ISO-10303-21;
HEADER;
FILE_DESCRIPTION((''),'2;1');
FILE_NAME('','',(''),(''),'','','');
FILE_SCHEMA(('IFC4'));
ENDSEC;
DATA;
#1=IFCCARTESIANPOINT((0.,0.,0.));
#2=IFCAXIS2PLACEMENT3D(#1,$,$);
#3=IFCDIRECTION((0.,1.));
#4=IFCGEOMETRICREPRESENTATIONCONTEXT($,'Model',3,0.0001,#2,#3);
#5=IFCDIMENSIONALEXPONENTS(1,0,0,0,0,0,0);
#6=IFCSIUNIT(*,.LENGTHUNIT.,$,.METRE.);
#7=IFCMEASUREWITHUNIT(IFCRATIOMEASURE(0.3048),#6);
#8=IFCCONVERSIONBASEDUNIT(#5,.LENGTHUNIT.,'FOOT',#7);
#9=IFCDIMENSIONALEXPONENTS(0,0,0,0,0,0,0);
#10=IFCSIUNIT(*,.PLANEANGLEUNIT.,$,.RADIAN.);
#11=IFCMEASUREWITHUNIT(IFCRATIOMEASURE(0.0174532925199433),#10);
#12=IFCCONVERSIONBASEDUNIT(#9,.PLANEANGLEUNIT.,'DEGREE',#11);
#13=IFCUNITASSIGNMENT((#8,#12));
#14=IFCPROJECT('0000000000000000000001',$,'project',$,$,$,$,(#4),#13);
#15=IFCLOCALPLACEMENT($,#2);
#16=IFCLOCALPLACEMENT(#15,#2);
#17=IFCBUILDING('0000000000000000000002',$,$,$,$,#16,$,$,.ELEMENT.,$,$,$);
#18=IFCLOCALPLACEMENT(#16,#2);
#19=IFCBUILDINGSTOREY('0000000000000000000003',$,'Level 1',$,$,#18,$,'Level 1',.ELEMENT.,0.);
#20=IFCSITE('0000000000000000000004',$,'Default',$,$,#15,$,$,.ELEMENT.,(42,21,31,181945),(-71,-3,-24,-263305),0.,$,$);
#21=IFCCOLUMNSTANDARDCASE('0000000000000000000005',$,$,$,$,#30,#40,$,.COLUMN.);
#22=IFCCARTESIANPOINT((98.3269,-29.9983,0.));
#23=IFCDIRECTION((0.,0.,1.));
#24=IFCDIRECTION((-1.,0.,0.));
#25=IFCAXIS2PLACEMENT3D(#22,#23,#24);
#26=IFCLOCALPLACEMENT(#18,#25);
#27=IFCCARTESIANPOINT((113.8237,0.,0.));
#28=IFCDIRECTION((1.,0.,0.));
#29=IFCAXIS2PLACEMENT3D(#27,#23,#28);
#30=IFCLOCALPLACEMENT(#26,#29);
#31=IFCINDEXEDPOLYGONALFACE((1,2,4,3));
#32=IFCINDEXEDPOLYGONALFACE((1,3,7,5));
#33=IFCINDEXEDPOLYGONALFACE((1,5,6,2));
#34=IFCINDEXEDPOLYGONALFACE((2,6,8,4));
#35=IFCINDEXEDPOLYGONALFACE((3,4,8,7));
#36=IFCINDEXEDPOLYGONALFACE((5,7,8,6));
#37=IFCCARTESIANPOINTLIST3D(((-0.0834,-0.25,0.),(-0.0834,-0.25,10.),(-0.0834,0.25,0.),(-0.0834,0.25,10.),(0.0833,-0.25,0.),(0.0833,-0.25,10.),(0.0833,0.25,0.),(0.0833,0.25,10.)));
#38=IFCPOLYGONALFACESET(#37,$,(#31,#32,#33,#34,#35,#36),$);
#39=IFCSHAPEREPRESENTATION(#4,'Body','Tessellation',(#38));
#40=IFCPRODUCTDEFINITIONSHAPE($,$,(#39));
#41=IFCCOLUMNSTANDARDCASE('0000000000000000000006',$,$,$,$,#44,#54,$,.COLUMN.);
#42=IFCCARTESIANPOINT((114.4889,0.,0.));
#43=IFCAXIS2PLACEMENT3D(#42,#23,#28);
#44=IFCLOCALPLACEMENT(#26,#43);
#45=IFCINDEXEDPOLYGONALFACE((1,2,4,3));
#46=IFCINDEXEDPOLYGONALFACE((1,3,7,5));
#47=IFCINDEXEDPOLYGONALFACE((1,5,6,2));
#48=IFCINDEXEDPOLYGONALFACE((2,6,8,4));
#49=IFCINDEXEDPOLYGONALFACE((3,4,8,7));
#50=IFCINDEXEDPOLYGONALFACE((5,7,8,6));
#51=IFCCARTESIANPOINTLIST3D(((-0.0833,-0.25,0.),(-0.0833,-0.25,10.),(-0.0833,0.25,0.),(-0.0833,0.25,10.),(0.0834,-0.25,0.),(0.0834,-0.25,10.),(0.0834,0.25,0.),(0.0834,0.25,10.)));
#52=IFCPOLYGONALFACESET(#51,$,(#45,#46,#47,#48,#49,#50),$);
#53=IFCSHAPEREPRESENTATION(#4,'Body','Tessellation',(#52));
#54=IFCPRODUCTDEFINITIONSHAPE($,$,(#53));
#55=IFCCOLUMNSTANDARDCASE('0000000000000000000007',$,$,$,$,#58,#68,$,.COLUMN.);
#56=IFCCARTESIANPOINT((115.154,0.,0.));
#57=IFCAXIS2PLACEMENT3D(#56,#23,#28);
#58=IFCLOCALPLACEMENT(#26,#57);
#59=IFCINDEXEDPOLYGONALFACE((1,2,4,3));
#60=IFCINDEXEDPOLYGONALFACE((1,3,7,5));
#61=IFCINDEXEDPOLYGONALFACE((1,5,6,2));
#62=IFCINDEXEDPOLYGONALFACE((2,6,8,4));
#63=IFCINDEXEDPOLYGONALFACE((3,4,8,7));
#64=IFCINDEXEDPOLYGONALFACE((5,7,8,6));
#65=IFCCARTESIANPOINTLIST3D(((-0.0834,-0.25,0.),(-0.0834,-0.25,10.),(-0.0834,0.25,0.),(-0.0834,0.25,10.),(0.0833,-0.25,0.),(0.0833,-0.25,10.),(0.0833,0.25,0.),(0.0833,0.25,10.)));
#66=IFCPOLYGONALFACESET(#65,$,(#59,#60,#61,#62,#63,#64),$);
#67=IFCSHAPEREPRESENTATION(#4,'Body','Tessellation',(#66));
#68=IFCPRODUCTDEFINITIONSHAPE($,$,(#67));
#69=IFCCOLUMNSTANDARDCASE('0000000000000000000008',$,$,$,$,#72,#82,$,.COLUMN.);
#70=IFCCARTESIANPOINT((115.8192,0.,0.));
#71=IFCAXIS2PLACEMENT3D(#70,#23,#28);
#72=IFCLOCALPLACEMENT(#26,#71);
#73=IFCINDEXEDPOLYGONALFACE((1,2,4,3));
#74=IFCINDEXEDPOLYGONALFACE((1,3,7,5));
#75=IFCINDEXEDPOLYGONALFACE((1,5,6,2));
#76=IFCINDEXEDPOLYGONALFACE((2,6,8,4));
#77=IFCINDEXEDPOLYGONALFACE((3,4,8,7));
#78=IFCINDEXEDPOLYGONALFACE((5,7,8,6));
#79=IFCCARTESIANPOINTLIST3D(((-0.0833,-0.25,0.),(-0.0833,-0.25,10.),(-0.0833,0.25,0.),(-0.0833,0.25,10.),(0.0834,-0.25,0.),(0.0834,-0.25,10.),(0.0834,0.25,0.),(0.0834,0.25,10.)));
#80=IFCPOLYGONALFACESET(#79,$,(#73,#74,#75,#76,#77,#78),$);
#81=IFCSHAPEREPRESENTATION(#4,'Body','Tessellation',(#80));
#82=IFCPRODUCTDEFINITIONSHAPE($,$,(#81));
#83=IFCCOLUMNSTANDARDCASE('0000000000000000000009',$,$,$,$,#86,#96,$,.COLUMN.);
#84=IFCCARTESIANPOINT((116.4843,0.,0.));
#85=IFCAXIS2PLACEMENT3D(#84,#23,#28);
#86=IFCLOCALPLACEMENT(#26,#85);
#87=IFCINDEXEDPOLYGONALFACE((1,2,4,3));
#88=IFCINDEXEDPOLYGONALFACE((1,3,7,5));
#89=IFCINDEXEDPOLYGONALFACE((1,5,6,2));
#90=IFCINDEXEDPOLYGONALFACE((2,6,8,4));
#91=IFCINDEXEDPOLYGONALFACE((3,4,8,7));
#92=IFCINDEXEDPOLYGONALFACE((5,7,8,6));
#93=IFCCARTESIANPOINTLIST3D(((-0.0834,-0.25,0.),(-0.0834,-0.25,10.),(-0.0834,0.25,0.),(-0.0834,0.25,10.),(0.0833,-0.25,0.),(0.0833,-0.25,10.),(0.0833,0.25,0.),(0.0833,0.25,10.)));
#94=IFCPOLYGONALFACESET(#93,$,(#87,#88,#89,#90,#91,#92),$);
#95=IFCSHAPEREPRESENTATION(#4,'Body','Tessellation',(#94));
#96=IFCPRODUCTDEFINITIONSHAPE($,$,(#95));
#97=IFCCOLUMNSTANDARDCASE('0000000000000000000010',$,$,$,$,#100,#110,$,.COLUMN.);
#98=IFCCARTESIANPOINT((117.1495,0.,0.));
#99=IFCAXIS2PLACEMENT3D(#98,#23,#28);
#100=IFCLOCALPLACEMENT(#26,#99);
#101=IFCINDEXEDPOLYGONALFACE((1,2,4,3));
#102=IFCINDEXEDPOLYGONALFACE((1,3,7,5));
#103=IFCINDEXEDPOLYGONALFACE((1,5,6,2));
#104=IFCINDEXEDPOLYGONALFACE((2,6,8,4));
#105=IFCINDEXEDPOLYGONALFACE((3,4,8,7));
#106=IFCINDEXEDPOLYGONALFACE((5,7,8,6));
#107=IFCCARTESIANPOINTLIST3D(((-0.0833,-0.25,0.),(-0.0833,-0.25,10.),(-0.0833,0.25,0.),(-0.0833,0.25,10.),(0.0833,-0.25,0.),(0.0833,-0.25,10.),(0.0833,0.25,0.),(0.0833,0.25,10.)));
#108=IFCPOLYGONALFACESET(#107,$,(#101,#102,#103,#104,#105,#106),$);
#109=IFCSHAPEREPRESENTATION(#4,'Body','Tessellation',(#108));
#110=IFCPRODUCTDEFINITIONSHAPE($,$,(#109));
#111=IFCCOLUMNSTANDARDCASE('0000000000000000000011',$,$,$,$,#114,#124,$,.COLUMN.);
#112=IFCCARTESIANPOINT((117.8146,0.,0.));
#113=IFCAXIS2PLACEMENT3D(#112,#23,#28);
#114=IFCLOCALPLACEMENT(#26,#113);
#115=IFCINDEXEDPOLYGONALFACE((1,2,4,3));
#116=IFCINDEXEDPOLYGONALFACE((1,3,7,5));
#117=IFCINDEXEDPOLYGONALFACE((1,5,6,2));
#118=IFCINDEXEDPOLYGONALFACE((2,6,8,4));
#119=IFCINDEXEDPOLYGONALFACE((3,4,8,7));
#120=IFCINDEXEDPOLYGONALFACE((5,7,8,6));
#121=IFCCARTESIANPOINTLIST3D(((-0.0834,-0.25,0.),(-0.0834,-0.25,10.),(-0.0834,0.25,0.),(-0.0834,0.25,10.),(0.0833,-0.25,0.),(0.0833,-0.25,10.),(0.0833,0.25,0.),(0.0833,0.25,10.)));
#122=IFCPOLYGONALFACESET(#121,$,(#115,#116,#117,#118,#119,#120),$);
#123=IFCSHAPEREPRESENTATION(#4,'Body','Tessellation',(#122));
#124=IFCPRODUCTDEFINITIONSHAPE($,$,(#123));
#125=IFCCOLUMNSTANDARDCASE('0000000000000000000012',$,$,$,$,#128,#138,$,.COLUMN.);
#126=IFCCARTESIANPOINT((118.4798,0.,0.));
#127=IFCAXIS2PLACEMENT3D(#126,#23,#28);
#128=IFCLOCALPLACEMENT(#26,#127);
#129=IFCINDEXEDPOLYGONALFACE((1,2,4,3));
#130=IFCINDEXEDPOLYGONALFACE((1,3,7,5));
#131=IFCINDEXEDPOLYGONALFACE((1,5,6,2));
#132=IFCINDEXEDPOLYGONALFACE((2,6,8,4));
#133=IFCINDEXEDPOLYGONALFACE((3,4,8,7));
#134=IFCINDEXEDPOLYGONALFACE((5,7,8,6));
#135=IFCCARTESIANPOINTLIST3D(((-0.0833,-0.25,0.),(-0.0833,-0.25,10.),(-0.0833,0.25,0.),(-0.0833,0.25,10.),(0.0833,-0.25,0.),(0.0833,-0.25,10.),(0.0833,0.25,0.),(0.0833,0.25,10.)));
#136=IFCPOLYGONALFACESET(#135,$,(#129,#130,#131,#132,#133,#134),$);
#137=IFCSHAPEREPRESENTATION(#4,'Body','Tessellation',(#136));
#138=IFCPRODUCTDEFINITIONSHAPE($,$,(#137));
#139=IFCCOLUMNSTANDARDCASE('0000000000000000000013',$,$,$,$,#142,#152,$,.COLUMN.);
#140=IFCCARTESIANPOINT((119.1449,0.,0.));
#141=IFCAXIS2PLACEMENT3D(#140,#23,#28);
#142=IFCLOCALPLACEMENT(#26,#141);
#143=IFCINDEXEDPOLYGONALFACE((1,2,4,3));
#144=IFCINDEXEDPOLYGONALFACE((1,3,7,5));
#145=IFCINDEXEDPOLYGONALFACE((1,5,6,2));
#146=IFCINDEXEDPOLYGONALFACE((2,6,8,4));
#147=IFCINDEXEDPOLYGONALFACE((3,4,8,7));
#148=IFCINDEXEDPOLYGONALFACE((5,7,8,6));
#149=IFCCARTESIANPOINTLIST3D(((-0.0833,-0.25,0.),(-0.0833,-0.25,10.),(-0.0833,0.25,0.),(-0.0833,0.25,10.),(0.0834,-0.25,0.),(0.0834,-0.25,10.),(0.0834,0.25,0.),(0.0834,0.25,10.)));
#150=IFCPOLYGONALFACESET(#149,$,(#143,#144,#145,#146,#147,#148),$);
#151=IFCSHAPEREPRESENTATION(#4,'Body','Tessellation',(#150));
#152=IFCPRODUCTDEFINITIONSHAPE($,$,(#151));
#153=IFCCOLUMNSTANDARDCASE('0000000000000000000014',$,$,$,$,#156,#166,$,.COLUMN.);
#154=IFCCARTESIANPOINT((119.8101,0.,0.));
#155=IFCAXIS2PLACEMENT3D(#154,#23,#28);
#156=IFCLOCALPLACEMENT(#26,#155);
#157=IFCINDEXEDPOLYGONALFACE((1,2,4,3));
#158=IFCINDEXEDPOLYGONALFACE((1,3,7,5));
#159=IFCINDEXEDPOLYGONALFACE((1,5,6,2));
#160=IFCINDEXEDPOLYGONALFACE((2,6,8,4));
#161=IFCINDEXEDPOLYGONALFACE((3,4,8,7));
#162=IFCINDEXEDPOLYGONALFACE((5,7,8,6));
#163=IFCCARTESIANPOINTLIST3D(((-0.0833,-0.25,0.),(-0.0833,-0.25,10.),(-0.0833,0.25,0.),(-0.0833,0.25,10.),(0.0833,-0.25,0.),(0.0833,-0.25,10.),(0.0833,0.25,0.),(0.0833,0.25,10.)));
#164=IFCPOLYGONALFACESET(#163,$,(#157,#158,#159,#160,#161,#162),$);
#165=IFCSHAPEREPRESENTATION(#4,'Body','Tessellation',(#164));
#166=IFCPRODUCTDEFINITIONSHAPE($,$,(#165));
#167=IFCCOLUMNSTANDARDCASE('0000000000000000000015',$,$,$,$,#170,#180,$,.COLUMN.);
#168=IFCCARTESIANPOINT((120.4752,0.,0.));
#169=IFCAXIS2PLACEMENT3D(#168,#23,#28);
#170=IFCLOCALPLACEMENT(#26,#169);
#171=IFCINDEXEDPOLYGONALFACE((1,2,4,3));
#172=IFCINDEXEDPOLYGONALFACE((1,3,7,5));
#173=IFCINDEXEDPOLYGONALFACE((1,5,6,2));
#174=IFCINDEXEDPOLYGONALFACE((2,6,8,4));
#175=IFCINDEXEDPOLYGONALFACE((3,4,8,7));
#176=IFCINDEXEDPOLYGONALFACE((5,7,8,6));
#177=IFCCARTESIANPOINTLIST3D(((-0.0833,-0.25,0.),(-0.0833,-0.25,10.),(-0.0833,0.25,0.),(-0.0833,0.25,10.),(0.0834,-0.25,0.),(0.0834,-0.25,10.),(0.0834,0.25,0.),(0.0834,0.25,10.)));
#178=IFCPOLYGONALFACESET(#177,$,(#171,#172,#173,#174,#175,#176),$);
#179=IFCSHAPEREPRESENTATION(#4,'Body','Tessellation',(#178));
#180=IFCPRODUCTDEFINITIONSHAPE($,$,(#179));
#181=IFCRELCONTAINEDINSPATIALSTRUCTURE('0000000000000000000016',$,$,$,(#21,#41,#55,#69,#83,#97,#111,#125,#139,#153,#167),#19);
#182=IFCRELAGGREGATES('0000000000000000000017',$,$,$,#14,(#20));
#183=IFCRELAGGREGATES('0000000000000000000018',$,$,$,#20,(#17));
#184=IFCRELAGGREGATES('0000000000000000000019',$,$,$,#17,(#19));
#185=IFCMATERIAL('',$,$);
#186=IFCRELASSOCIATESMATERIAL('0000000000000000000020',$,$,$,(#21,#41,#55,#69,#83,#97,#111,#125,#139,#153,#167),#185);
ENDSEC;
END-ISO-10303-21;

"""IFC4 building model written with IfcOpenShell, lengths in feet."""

from ifc_helpers import new_model, entity, si_unit, converted_unit, direction, frame, origin, place, context, project, spatial, rectangle, extrude, material, element, save


model = new_model("IFC4")

# Units and contexts
model_context = context("Model", 3, precision=0.0001, world=origin(), true_north=direction((0.0, 1.0)))
ifc_project = project(units=[converted_unit("LENGTHUNIT", "FOOT", entity("IfcRatioMeasure", 0.3048), si_unit("LENGTHUNIT", "METRE"), dimensions=[1, 0, 0, 0, 0, 0, 0]), converted_unit("PLANEANGLEUNIT", "DEGREE", entity("IfcRatioMeasure", 0.0174532925199433), si_unit("PLANEANGLEUNIT", "RADIAN"), dimensions=[0, 0, 0, 0, 0, 0, 0])], contexts=[model_context])

# Site, building, storey
site_placement = place(None, origin())
site = spatial("IfcSite", under=ifc_project, at=site_placement, Name="Default", CompositionType="ELEMENT", RefLatitude=(42, 21, 31, 181945), RefLongitude=(-71, -3, -24, -263305), RefElevation=0.0)
building_placement = place(site_placement, origin())
building = spatial("IfcBuilding", under=site, at=building_placement, CompositionType="ELEMENT")
storey_placement = place(building_placement, origin())
storey = spatial("IfcBuildingStorey", under=building, at=storey_placement, Name="Level 1", LongName="Level 1", CompositionType="ELEMENT", Elevation=0.0)

# Columns
ifc_material = material(Name="")
placement = place(storey_placement, frame((98.3269, -29.9983, 0.0), z_axis=(0.0, 0.0, 1.0), x_axis=(-1.0, 0.0, 0.0)))
for number, where, z_axis, x_axis in (
    (1, (113.8237, 0.0, 0.0), (0.0, 0.0, 1.0), (1.0, 0.0, 0.0)),
    (2, (114.4889, 0.0, 0.0), (0.0, 0.0, 1.0), (1.0, 0.0, 0.0)),
    (3, (115.154, 0.0, 0.0), (0.0, 0.0, 1.0), (1.0, 0.0, 0.0)),
    (4, (115.8192, 0.0, 0.0), (0.0, 0.0, 1.0), (1.0, 0.0, 0.0)),
    (5, (116.4843, 0.0, 0.0), (0.0, 0.0, 1.0), (1.0, 0.0, 0.0)),
    (6, (117.1495, 0.0, 0.0), (0.0, 0.0, 1.0), (1.0, 0.0, 0.0)),
    (7, (117.8146, 0.0, 0.0), (0.0, 0.0, 1.0), (1.0, 0.0, 0.0)),
    (8, (118.4798, 0.0, 0.0), (0.0, 0.0, 1.0), (1.0, 0.0, 0.0)),
    (9, (119.1449, 0.0, 0.0), (0.0, 0.0, 1.0), (1.0, 0.0, 0.0)),
    (10, (119.8101, 0.0, 0.0), (0.0, 0.0, 1.0), (1.0, 0.0, 0.0)),
    (11, (120.4752, 0.0, 0.0), (0.0, 0.0, 1.0), (1.0, 0.0, 0.0)),
):
    element("IfcColumnStandardCase", number, at=place(placement, frame(where, z_axis=z_axis, x_axis=x_axis)), inside=storey, material=ifc_material, PredefinedType="COLUMN", context=model_context, shape_type="SweptSolid", body=[
        extrude(rectangle(XDim=0.1667, YDim=0.5), origin(), (0.0, 0.0, 1.0), 10.0),
    ])

save(model, "model.ifc")
